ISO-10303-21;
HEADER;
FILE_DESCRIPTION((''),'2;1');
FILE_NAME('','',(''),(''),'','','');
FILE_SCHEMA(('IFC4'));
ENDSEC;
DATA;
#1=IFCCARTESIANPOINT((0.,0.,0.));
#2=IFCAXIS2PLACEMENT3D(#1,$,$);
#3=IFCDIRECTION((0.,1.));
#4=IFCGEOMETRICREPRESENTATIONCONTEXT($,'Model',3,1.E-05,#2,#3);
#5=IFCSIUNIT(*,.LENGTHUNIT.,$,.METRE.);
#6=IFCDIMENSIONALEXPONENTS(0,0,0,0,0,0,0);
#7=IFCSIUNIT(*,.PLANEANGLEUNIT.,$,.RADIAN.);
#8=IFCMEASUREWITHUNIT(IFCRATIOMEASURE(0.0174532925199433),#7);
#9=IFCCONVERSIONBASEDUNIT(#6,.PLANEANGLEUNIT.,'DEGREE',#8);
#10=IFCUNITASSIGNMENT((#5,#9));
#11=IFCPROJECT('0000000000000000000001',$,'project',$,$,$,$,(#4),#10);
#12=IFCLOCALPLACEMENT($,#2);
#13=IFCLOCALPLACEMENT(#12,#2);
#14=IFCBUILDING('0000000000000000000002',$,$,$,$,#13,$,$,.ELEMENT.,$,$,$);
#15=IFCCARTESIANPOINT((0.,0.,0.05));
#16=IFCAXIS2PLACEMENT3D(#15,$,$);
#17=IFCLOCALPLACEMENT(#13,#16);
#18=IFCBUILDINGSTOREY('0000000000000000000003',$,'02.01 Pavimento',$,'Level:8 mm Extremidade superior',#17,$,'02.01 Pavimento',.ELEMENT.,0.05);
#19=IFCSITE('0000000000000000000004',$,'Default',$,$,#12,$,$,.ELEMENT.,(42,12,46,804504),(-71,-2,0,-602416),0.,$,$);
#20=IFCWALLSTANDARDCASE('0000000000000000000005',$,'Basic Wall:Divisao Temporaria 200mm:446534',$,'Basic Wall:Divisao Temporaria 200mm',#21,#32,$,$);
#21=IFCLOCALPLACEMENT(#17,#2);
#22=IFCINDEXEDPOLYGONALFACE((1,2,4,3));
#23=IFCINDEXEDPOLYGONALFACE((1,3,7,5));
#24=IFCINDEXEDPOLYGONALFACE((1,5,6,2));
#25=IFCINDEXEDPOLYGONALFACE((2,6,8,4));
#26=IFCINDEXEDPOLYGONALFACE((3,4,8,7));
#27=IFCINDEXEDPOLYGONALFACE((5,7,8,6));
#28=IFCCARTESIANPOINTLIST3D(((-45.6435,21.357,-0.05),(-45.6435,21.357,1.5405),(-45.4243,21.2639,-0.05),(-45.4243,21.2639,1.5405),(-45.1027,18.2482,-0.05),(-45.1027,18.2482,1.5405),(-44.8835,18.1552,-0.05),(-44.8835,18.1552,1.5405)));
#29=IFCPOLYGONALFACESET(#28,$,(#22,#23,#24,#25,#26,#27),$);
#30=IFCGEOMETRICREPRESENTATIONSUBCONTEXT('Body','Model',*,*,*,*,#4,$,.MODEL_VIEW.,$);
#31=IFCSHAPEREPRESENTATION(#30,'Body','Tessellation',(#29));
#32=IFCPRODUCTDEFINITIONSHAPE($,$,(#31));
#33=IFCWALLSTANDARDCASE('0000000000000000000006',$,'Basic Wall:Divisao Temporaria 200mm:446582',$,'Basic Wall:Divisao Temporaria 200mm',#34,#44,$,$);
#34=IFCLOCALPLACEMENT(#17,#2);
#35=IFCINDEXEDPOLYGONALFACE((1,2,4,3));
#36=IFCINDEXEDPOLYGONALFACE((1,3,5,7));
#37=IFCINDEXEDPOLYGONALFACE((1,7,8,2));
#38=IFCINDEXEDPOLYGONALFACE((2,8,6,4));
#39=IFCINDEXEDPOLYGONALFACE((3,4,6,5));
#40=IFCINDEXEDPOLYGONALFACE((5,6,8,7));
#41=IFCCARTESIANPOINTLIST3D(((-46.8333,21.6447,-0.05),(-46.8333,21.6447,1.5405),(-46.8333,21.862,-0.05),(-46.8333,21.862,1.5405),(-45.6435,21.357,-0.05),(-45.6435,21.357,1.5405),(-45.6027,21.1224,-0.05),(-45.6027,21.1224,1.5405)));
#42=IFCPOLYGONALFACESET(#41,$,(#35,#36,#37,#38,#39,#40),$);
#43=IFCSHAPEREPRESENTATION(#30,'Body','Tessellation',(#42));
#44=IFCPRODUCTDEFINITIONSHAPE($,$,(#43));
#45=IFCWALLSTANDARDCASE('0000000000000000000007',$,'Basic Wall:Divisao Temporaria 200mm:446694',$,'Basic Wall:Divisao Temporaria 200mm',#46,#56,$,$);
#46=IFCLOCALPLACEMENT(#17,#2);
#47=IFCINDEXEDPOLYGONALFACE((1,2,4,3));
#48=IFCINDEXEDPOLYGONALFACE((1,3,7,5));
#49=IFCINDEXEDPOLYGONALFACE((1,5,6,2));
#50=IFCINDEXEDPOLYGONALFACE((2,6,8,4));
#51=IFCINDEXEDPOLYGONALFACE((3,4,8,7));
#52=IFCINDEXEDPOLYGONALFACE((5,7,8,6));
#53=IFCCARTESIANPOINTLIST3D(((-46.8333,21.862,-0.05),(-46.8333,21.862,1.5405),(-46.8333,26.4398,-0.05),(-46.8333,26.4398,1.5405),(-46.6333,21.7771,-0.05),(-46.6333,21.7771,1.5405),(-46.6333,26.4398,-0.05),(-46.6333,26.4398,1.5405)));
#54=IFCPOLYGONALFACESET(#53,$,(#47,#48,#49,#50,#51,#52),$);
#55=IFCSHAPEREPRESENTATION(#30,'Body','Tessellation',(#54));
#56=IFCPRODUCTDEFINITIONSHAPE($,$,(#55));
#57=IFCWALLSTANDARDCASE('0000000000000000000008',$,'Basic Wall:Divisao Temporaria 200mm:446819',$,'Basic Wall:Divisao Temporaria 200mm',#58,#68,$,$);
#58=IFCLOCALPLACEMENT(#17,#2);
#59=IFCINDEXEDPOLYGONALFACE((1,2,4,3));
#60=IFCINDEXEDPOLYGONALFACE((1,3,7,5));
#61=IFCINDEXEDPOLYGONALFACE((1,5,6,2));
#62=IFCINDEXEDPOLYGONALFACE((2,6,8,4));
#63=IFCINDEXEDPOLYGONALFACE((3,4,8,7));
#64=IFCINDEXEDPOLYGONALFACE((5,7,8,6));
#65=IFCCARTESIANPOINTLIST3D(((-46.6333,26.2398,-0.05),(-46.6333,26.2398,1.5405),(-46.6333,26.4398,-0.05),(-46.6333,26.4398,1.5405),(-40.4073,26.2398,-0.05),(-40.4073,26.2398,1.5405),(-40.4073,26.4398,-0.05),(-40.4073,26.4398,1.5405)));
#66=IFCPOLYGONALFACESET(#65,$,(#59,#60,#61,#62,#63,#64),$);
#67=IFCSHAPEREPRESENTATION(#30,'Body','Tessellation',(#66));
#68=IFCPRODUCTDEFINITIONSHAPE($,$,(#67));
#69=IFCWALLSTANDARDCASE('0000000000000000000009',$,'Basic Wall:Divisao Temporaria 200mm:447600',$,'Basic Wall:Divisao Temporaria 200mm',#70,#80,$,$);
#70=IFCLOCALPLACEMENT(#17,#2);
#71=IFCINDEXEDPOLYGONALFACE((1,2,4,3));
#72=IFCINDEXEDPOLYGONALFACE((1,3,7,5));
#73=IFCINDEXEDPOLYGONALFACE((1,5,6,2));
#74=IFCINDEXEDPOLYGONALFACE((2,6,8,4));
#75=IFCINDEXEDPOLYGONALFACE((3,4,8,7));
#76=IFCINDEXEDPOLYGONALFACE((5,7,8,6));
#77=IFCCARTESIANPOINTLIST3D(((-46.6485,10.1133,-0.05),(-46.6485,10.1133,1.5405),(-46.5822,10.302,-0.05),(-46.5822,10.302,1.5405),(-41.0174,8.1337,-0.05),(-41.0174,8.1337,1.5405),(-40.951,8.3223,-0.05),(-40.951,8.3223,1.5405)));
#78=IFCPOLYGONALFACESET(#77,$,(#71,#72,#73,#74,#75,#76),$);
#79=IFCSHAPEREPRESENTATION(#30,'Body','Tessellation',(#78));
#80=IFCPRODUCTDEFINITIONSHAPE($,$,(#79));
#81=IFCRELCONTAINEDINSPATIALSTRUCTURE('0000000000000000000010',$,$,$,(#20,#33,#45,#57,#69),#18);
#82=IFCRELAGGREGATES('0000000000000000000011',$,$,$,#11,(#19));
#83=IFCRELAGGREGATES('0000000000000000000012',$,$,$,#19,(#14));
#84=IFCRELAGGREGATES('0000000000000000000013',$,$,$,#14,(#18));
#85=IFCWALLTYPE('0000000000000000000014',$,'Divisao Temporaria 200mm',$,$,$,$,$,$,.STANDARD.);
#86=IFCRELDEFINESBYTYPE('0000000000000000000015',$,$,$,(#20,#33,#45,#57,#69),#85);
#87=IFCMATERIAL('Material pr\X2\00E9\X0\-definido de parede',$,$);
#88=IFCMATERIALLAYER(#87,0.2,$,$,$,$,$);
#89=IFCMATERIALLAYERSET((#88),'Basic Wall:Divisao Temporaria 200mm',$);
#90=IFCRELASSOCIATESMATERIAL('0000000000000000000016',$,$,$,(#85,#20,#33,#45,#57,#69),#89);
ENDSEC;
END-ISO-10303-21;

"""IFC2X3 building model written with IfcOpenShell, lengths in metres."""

from ifc_helpers import new_model, entity, si_unit, converted_unit, direction, frame, frame_2d, origin, place, context, subcontext, project, spatial, polyline, rectangle, outline, extrude, clip, halfspace, material, layer, layer_set, layer_usage, type_object, element, save


model = new_model("IFC2X3")

# Units and contexts
model_context = context("Model", 3, precision=1e-05, world=origin(), true_north=direction((0.0, 1.0)))
body_context = subcontext(model_context, "Body", "Model", "MODEL_VIEW")
ifc_project = project(units=[si_unit("LENGTHUNIT", "METRE"), converted_unit("PLANEANGLEUNIT", "DEGREE", entity("IfcRatioMeasure", 0.0174532925199433), si_unit("PLANEANGLEUNIT", "RADIAN"), dimensions=[0, 0, 0, 0, 0, 0, 0])], contexts=[model_context])

# Site, building, storey
site_placement = place(None, origin())
site = spatial("IfcSite", under=ifc_project, at=site_placement, Name="Default", CompositionType="ELEMENT", RefLatitude=(42, 12, 46, 804504), RefLongitude=(-71, -2, 0, -602416), RefElevation=0.0)
building_placement = place(site_placement, origin())
building = spatial("IfcBuilding", under=site, at=building_placement, CompositionType="ELEMENT")
storey_placement = place(building_placement, frame((0.0, 0.0, 0.05)))
storey = spatial("IfcBuildingStorey", under=building, at=storey_placement, Name="02.01 Pavimento", ObjectType="Level:8 mm Extremidade superior", LongName="02.01 Pavimento", CompositionType="ELEMENT", Elevation=0.05)

# Shared definitions
ifc_material_1 = material(Name="Material pré-definido de parede")

# Walls
ifc_layer_1 = layer(ifc_material_1, 0.2)
ifc_layer_set_1 = layer_set([ifc_layer_1], Name="Basic Wall:Divisao Temporaria 200mm")
wall_type_1 = type_object("IfcWallType", Name="Divisao Temporaria 200mm", PredefinedType="STANDARD", material=ifc_layer_set_1)
ifc_layer_usage_1 = layer_usage(ifc_layer_set_1, "AXIS2", "NEGATIVE", 0.1)
wall_1_placement = place(storey_placement, frame((-44.9821, 18.1381, -0.05), z_axis=(0.0, 0.0, 1.0), x_axis=(-0.17138, 0.985205, 0.0)))
element("IfcWallStandardCase", 1, at=wall_1_placement, inside=storey, type_object=wall_type_1, material=ifc_layer_usage_1, Name="Basic Wall:Divisao Temporaria 200mm:446534", ObjectType="Basic Wall:Divisao Temporaria 200mm", context=body_context, shape_type="Clipping", body=[
    clip(extrude(outline(polyline([(3.1554, -0.1), (3.2846, 0.1), (3.0465, 0.1), (0.1292, 0.1), (0.0, -0.1), (3.1554, -0.1)])), origin(), (0.0, 0.0, 1.0), 1.5905), halfspace(frame((0.0, 0.0, -0.05)), True)),
])
ifc_layer_usage_2 = layer_usage(ifc_layer_set_1, "AXIS2", "NEGATIVE", 0.1)
wall_2_placement = place(storey_placement, frame((-45.5636, 21.2144, -0.05), z_axis=(0.0, 0.0, 1.0), x_axis=(-0.920505, 0.390731, 0.0)))
element("IfcWallStandardCase", 2, at=wall_2_placement, inside=storey, type_object=wall_type_1, material=ifc_layer_usage_2, Name="Basic Wall:Divisao Temporaria 200mm:446582", ObjectType="Basic Wall:Divisao Temporaria 200mm", context=body_context, shape_type="Clipping", body=[
    clip(extrude(outline(polyline([(1.4218, -0.1), (1.3369, 0.1), (0.0, 0.1), (0.1292, -0.1), (1.2045, -0.1), (1.4218, -0.1)])), origin(), (0.0, 0.0, 1.0), 1.5905), halfspace(frame((0.0, 0.0, -0.05)), True)),
])
ifc_layer_usage_3 = layer_usage(ifc_layer_set_1, "AXIS2", "NEGATIVE", 0.1)
wall_3_placement = place(storey_placement, frame((-46.7333, 21.7771, -0.05), z_axis=(0.0, 0.0, 1.0), x_axis=(0.0, 1.0, 0.0)))
element("IfcWallStandardCase", 3, at=wall_3_placement, inside=storey, type_object=wall_type_1, material=ifc_layer_usage_3, Name="Basic Wall:Divisao Temporaria 200mm:446694", ObjectType="Basic Wall:Divisao Temporaria 200mm", context=body_context, shape_type="Clipping", body=[
    clip(extrude(outline(polyline([(4.6627, -0.1), (4.6627, 0.1), (0.0849, 0.1), (0.0, -0.1), (4.4627, -0.1), (4.6627, -0.1)])), origin(), (0.0, 0.0, 1.0), 1.5905), halfspace(frame((0.0, 0.0, -0.05)), True)),
])
ifc_layer_usage_4 = layer_usage(ifc_layer_set_1, "AXIS2", "NEGATIVE", 0.1)
wall_4_placement = place(storey_placement, frame((-46.6333, 26.3398, -0.05)))
element("IfcWallStandardCase", 4, at=wall_4_placement, inside=storey, type_object=wall_type_1, material=ifc_layer_usage_4, Name="Basic Wall:Divisao Temporaria 200mm:446819", ObjectType="Basic Wall:Divisao Temporaria 200mm", context=body_context, shape_type="Clipping", body=[
    clip(extrude(rectangle(XDim=6.226, YDim=0.2, at=frame_2d((3.113, 0.0), x_axis=(-1.0, 0.0))), origin(), (0.0, 0.0, 1.0), 1.5905), halfspace(frame((0.0, 0.0, -0.05)), True)),
])
ifc_layer_usage_5 = layer_usage(ifc_layer_set_1, "AXIS2", "NEGATIVE", 0.1)
wall_5_placement = place(storey_placement, frame((-40.9842, 8.228, -0.05), z_axis=(0.0, 0.0, 1.0), x_axis=(-0.943402, 0.331652, 0.0)))
element("IfcWallStandardCase", 5, at=wall_5_placement, inside=storey, type_object=wall_type_1, material=ifc_layer_usage_5, Name="Basic Wall:Divisao Temporaria 200mm:447600", ObjectType="Basic Wall:Divisao Temporaria 200mm", context=body_context, shape_type="Clipping", body=[
    clip(extrude(rectangle(XDim=5.969, YDim=0.2, at=frame_2d((2.9845, 0.0), x_axis=(-1.0, 0.0))), origin(), (0.0, 0.0, 1.0), 1.5905), halfspace(frame((0.0, 0.0, -0.05)), True)),
])

save(model, "model.ifc")
